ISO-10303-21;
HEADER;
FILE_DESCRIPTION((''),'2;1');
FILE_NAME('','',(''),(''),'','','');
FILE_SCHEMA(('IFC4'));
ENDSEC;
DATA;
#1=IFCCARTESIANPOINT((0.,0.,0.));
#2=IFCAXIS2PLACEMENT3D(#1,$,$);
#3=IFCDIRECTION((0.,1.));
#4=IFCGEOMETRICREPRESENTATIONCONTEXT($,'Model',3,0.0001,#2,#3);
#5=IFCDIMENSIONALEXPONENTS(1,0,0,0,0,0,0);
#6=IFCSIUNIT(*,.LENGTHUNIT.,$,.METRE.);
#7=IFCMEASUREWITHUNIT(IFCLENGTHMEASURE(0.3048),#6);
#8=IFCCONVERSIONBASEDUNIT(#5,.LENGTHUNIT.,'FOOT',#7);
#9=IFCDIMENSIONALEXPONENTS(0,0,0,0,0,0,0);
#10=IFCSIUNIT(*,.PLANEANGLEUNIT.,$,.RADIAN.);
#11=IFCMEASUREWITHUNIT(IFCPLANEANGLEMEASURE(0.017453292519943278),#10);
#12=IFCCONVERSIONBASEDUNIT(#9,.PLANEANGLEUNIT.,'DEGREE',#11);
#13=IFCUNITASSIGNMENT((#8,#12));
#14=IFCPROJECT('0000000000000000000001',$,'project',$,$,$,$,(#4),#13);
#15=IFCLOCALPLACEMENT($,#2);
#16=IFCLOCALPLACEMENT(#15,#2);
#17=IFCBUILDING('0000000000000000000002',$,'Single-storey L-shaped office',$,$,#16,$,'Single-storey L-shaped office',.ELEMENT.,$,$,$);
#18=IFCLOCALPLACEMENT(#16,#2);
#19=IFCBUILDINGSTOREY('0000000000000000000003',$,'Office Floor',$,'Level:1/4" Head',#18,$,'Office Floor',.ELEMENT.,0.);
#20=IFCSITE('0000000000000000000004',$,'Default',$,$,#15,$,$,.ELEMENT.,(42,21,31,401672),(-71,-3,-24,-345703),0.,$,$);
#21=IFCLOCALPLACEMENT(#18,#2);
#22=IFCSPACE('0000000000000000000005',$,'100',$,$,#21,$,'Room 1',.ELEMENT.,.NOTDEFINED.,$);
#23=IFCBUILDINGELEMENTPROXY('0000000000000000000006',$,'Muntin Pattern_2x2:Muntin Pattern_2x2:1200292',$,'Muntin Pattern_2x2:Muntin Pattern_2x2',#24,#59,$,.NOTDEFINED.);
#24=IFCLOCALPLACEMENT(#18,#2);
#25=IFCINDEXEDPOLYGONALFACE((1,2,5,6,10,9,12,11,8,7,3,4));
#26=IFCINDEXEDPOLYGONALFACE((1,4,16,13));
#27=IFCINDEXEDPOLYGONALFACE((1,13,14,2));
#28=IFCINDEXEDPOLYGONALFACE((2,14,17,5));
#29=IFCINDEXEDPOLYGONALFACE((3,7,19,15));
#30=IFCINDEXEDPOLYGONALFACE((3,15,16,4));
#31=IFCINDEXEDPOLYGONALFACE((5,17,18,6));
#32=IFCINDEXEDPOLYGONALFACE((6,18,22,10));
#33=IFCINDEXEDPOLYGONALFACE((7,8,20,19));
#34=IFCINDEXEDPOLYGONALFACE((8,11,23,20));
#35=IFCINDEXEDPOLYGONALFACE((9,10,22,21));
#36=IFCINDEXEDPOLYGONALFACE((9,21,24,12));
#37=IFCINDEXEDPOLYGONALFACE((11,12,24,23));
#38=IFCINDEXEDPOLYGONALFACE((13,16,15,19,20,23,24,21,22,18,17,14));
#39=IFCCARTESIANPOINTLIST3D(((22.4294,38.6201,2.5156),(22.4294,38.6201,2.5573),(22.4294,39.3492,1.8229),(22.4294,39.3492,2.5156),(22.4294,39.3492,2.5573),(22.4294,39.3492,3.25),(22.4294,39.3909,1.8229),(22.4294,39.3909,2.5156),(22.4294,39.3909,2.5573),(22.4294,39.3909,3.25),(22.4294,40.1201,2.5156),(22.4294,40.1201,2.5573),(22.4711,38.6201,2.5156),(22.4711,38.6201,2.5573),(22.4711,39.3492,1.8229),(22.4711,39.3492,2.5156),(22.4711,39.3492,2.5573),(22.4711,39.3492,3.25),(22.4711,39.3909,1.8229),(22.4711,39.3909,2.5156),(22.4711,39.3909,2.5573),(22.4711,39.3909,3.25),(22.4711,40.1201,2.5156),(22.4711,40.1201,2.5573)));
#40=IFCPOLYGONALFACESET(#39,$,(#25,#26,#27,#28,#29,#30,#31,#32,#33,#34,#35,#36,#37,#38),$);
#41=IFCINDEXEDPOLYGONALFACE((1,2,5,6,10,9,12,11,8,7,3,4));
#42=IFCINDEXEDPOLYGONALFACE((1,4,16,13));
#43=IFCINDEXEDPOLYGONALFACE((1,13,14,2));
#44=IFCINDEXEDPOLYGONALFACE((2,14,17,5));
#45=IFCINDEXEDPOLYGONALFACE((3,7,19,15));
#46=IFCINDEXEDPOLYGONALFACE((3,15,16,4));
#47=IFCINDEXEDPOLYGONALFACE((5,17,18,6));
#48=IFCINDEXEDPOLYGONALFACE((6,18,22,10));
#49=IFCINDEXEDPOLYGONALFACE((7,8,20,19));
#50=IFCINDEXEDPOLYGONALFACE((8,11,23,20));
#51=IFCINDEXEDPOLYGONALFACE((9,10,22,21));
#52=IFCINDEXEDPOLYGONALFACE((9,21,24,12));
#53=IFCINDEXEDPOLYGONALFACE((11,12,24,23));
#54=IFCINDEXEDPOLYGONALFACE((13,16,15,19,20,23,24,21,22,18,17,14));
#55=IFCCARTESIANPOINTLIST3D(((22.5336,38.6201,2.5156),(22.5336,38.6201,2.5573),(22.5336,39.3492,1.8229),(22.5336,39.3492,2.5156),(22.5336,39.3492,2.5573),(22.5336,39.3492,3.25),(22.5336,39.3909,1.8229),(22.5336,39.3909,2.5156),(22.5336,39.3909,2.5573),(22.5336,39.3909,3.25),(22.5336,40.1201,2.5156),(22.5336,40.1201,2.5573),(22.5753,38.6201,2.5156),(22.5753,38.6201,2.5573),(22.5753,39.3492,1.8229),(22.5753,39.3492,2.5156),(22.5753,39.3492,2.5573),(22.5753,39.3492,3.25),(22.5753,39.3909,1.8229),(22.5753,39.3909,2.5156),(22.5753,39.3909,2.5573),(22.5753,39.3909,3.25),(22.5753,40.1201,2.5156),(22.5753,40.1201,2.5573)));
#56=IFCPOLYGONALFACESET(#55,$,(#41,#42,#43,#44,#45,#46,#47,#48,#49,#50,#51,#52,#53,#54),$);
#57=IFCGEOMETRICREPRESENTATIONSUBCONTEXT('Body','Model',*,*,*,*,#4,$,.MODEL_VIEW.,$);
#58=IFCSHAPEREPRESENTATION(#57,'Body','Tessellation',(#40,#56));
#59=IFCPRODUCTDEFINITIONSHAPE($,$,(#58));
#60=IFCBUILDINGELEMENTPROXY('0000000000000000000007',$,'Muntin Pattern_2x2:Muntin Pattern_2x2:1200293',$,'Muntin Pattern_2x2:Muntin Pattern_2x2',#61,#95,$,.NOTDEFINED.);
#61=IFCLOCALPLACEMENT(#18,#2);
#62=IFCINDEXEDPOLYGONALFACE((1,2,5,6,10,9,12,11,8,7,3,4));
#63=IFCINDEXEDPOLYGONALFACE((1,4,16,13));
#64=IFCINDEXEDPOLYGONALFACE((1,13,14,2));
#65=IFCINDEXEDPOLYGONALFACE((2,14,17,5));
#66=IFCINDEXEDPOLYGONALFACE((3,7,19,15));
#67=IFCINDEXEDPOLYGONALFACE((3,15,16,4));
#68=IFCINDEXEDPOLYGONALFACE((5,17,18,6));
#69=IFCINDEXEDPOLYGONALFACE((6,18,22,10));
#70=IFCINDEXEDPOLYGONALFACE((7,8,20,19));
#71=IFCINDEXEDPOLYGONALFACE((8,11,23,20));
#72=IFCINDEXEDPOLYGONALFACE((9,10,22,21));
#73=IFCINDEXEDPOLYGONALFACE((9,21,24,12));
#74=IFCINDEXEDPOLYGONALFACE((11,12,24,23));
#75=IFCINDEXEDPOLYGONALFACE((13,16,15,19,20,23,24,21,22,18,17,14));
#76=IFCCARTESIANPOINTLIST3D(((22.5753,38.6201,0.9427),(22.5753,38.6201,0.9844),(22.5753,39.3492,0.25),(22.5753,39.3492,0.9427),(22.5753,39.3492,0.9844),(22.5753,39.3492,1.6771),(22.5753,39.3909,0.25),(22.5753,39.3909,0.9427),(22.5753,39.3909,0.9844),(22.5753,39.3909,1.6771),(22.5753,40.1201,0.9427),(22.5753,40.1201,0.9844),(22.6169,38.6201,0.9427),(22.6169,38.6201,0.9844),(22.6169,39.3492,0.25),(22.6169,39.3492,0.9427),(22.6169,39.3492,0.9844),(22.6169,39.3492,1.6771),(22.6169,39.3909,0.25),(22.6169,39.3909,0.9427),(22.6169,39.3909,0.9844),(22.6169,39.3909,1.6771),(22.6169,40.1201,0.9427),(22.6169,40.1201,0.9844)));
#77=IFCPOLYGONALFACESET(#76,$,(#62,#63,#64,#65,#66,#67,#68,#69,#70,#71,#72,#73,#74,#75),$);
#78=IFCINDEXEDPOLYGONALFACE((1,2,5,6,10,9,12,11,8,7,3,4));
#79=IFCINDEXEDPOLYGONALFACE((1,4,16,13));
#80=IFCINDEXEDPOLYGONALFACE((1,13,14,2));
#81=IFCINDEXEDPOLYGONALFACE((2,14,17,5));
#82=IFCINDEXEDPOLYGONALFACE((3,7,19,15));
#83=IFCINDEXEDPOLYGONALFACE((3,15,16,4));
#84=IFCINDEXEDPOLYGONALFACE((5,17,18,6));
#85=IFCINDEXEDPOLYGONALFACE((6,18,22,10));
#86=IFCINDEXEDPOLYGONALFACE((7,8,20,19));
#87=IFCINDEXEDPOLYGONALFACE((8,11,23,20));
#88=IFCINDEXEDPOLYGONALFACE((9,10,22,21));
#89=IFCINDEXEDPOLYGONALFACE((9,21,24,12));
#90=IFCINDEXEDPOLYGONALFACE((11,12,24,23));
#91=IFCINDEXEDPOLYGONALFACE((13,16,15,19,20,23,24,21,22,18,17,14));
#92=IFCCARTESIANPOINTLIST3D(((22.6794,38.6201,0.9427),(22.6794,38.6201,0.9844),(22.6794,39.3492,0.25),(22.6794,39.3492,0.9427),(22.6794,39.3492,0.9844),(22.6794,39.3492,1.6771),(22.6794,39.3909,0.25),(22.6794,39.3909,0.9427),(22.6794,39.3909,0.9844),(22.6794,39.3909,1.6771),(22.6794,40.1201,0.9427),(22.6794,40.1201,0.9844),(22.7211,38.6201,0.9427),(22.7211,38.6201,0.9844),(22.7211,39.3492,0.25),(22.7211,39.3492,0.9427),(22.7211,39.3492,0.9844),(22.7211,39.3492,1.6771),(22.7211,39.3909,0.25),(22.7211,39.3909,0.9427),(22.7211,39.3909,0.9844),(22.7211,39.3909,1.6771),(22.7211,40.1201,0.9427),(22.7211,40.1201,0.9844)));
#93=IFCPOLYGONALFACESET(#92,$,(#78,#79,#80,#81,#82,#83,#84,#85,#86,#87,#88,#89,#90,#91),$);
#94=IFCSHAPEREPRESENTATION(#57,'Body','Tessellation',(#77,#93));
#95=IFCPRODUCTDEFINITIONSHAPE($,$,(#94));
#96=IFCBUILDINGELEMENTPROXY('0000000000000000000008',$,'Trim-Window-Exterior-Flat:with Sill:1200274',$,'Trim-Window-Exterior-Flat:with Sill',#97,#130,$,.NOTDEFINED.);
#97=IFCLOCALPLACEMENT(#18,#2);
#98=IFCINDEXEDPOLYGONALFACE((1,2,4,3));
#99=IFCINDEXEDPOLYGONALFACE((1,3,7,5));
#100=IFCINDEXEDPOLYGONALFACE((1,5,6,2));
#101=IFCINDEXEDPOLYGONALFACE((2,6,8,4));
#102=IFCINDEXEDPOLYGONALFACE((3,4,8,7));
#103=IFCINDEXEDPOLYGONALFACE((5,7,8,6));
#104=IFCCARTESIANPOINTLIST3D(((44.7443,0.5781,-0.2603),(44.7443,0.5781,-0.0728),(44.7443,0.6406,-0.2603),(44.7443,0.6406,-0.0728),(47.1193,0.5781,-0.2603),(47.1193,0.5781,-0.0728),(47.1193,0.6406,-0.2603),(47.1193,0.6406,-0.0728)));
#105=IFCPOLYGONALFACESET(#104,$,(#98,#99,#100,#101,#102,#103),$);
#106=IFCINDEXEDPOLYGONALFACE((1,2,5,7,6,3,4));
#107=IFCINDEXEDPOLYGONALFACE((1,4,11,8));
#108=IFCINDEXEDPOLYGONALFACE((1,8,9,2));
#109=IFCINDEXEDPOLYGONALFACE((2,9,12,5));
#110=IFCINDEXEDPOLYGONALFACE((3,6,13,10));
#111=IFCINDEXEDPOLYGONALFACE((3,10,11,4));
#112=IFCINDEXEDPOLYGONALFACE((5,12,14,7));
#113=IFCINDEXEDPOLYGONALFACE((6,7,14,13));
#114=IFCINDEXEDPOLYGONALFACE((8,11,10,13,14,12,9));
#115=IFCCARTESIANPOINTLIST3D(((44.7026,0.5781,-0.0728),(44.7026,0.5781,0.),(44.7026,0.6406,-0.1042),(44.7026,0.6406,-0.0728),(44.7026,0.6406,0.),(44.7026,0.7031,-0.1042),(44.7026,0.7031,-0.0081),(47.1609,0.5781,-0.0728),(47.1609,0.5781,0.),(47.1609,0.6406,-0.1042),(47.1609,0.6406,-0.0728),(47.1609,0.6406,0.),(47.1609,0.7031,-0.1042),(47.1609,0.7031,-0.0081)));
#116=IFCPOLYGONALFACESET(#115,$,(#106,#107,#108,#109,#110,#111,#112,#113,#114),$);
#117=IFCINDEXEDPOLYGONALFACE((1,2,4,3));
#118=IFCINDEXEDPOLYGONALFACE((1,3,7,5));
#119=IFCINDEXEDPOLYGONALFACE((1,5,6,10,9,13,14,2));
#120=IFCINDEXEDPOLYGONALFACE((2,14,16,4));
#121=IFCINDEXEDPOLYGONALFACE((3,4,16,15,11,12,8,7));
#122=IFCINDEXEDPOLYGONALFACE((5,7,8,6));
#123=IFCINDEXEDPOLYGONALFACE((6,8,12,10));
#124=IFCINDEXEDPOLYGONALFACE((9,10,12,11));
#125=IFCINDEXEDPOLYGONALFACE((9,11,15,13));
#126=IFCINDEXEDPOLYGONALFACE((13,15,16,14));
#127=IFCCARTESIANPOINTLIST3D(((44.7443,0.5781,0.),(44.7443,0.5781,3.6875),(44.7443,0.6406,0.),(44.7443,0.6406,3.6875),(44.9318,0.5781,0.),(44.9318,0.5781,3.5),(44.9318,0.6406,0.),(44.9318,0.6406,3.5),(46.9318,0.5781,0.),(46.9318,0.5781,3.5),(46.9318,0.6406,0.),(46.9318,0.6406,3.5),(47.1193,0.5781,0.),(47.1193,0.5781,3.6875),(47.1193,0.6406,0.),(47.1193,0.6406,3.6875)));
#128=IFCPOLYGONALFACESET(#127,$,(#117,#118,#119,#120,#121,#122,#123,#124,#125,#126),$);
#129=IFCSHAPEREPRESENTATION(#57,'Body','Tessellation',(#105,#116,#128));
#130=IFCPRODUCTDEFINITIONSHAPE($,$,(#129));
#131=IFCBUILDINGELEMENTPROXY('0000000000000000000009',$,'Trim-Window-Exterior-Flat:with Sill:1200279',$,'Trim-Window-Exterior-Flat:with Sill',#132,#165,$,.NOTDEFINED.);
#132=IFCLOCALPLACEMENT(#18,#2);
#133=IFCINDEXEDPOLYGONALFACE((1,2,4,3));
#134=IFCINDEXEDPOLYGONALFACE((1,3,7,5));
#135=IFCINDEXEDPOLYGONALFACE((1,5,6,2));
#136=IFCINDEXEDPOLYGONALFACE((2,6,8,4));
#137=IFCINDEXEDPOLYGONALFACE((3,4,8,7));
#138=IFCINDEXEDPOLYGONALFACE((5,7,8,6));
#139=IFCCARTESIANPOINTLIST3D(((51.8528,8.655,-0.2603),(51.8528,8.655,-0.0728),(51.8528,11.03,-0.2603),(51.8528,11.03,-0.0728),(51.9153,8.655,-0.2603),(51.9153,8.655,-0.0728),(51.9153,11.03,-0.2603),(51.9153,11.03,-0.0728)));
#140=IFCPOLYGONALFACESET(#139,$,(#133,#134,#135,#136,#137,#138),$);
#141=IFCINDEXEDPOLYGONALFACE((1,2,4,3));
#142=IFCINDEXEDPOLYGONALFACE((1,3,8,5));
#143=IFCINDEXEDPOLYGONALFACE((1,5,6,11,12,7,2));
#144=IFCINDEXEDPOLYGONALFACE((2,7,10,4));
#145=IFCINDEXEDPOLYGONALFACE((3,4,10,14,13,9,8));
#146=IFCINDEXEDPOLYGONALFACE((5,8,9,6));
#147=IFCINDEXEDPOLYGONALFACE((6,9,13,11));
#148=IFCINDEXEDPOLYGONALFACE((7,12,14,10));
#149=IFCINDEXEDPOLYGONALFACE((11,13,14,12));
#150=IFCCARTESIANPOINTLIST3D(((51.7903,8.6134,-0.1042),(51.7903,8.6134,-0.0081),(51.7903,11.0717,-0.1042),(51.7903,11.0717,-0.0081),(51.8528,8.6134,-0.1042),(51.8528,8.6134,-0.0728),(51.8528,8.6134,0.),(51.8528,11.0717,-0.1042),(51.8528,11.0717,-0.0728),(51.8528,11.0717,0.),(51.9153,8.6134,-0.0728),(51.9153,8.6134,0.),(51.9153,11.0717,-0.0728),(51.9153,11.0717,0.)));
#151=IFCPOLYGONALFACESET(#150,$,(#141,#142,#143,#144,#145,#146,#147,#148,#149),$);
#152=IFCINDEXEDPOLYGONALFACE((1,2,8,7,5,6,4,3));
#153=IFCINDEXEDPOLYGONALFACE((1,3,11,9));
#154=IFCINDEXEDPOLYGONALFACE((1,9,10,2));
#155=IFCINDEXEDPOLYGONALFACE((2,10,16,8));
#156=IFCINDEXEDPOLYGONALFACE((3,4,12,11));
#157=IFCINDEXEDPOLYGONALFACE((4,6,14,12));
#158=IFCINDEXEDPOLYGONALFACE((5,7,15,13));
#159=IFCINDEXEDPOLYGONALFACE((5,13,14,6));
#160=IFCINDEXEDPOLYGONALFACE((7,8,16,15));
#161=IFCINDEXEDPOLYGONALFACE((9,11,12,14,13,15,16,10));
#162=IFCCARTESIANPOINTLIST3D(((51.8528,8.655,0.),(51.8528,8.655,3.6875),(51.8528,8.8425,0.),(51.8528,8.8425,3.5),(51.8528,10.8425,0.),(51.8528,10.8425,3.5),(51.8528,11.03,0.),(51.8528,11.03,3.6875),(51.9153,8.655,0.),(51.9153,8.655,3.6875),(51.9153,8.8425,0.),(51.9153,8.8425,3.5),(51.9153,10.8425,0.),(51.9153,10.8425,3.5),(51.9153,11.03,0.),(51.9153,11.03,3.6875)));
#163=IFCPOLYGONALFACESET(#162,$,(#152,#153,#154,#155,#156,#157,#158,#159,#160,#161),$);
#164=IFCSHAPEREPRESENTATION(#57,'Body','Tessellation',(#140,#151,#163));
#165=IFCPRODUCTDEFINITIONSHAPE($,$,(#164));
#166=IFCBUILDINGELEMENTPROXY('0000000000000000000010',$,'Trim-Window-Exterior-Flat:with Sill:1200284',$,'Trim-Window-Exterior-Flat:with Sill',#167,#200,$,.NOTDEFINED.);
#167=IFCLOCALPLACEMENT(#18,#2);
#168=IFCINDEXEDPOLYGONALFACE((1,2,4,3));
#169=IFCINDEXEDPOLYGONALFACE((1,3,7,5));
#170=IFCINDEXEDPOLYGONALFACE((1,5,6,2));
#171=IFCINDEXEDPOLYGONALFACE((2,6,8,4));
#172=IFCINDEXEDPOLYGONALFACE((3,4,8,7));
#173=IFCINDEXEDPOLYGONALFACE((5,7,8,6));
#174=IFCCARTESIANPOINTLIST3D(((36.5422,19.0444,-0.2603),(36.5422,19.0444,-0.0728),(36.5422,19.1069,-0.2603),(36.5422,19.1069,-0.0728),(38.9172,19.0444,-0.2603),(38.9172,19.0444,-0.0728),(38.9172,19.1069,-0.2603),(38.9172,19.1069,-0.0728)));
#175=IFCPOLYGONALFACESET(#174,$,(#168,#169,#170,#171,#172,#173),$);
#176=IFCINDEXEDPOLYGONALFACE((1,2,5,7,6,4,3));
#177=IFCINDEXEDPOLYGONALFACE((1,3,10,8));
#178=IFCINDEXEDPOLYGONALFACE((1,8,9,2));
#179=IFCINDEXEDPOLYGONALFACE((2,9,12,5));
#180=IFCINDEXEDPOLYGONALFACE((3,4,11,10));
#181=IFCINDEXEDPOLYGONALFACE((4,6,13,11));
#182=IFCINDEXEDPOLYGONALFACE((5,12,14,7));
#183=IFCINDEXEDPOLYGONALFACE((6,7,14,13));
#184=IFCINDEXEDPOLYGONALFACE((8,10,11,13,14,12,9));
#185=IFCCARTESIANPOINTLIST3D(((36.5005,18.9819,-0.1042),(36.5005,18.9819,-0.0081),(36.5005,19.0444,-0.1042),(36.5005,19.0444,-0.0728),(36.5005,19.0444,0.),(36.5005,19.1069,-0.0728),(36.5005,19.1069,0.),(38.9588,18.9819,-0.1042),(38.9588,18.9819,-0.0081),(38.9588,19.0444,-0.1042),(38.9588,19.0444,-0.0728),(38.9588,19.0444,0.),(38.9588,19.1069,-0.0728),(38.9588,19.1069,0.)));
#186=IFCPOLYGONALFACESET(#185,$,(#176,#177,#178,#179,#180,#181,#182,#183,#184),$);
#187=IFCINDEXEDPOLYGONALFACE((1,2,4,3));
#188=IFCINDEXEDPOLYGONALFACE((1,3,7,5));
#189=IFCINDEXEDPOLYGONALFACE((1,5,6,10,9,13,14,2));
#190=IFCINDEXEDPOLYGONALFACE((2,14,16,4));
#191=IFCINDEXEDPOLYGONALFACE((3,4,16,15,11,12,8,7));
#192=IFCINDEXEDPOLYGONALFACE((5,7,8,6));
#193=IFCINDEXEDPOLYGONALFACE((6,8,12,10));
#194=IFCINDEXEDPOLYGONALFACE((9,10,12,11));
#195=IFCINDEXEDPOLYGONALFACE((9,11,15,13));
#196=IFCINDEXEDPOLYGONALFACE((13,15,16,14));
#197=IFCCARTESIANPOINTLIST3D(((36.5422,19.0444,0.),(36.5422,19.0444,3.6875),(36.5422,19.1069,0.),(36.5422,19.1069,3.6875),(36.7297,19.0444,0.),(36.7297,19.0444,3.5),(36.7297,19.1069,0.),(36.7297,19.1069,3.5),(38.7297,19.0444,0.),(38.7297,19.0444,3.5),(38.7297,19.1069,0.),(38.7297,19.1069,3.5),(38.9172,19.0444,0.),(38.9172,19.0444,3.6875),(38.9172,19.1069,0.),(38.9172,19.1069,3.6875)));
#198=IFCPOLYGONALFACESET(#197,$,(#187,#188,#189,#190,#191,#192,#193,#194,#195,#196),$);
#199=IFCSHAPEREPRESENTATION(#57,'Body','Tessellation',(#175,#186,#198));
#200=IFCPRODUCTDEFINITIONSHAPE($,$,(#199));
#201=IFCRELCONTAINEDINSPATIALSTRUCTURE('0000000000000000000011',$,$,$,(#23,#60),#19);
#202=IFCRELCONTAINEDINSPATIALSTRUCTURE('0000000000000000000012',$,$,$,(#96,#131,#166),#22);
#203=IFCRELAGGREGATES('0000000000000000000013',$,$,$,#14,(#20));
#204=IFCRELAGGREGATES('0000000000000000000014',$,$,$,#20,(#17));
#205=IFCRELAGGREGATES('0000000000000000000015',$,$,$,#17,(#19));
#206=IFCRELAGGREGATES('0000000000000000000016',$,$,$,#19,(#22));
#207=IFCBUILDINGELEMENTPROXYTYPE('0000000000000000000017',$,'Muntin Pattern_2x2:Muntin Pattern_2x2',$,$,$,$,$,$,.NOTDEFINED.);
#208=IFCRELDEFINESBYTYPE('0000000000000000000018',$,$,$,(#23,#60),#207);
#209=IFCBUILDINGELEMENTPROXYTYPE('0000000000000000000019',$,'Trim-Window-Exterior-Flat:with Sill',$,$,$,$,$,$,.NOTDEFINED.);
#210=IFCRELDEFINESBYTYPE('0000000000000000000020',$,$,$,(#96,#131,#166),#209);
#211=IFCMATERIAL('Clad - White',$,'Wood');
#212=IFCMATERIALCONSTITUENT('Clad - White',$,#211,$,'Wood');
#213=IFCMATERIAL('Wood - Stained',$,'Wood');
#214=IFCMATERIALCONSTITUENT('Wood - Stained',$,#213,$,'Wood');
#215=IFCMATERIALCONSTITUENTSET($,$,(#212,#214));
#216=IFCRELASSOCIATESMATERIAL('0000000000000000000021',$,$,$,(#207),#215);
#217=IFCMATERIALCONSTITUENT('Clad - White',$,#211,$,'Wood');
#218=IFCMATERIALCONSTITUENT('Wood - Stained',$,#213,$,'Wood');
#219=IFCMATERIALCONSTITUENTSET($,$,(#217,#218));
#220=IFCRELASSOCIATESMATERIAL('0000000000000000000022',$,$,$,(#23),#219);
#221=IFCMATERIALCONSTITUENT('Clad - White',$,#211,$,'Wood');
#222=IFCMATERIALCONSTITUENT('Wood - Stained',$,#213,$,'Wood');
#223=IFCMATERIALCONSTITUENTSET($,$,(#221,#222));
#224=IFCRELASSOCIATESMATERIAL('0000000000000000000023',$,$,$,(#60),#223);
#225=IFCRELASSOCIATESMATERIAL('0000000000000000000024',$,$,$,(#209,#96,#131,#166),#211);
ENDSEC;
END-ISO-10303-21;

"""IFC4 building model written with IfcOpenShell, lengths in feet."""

from ifc_helpers import new_model, entity, si_unit, converted_unit, direction, frame, origin, place, context, subcontext, project, spatial, indexed_curve, outline, extrude, source, transform, mapped, material, constituent, constituent_set, type_object, type_shapes, element, save


model = new_model("IFC4")

# Units and contexts
model_context = context("Model", 3, precision=0.0001, world=origin(), true_north=direction((0.0, 1.0)))
body_context = subcontext(model_context, "Body", "Model", "MODEL_VIEW")
ifc_project = project(units=[converted_unit("LENGTHUNIT", "FOOT", entity("IfcLengthMeasure", 0.3048), si_unit("LENGTHUNIT", "METRE"), dimensions=[1, 0, 0, 0, 0, 0, 0]), converted_unit("PLANEANGLEUNIT", "DEGREE", entity("IfcPlaneAngleMeasure", 0.017453292519943278), si_unit("PLANEANGLEUNIT", "RADIAN"), dimensions=[0, 0, 0, 0, 0, 0, 0])], contexts=[model_context])

# Site, building, storey
site_placement = place(None, origin())
site = spatial("IfcSite", under=ifc_project, at=site_placement, Name="Default", CompositionType="ELEMENT", RefLatitude=(42, 21, 31, 401672), RefLongitude=(-71, -3, -24, -345703), RefElevation=0.0)
building_placement = place(site_placement, origin())
building = spatial("IfcBuilding", under=site, at=building_placement, Name="Single-storey L-shaped office", LongName="Single-storey L-shaped office", CompositionType="ELEMENT")
storey_placement = place(building_placement, origin())
storey = spatial("IfcBuildingStorey", under=building, at=storey_placement, Name="Office Floor", ObjectType="Level:1/4\" Head", LongName="Office Floor", CompositionType="ELEMENT", Elevation=0.0)

# Shared definitions
ifc_material_1 = material(Name="Wood - Stained", Category="Wood")

# Building element proxies
ifc_material_2 = material(Name="Clad - White", Category="Wood")
ifc_constituent_1 = constituent(ifc_material_2, Name="Clad - White", Category="Wood")
ifc_constituent_2 = constituent(ifc_material_1, Name="Wood - Stained", Category="Wood")
ifc_constituent_set_1 = constituent_set(constituents=[ifc_constituent_1, ifc_constituent_2])
building_element_proxy_type_1 = type_object("IfcBuildingElementProxyType", Name="Muntin Pattern_2x2:Muntin Pattern_2x2", PredefinedType="NOTDEFINED", material=ifc_constituent_set_1)
shared_shape_1 = source(origin(), body_context, "Body", "SweptSolid", [
    extrude(outline(indexed_curve([(0.0208, -0.0208), (0.7135, -0.0208), (0.7135, 0.0208), (0.0208, 0.0208), (0.0208, 0.75), (-0.0208, 0.75), (-0.0208, 0.0208), (-0.7135, 0.0208), (-0.7135, -0.0208), (-0.0208, -0.0208), (-0.0208, -0.75), (0.0208, -0.75), (0.0208, -0.0208)], self_intersect=False)), frame((0.0, 0.0312, 0.7135), z_axis=(0.0, 1.0, 0.0), x_axis=(0.0, 0.0, 1.0)), (0.0, 0.0, 1.0), 0.0417),
    extrude(outline(indexed_curve([(0.0208, -0.0208), (0.7135, -0.0208), (0.7135, 0.0208), (0.0208, 0.0208), (0.0208, 0.75), (-0.0208, 0.75), (-0.0208, 0.0208), (-0.7135, 0.0208), (-0.7135, -0.0208), (-0.0208, -0.0208), (-0.0208, -0.75), (0.0208, -0.75), (0.0208, -0.0208)], self_intersect=False)), frame((0.0, -0.0729, 0.7135), z_axis=(0.0, 1.0, 0.0), x_axis=(0.0, 0.0, 1.0)), (0.0, 0.0, 1.0), 0.0417),
])
type_shapes(building_element_proxy_type_1, [shared_shape_1])
ifc_constituent_3 = constituent(ifc_material_2, Name="Clad - White", Category="Wood")
ifc_constituent_4 = constituent(ifc_material_1, Name="Wood - Stained", Category="Wood")
ifc_constituent_set_2 = constituent_set(constituents=[ifc_constituent_3, ifc_constituent_4])
proxy_1_placement = place(storey_placement, frame((22.5023, 39.3701, 1.8229), z_axis=(0.0, 0.0, 1.0), x_axis=(0.0, 1.0, 0.0)))
element("IfcBuildingElementProxy", 1, at=proxy_1_placement, inside=storey, type_object=building_element_proxy_type_1, material=ifc_constituent_set_2, Name="Muntin Pattern_2x2:Muntin Pattern_2x2:1200292", ObjectType="Muntin Pattern_2x2:Muntin Pattern_2x2", PredefinedType="NOTDEFINED", context=body_context, shape_type="MappedRepresentation", body=[
    mapped(shared_shape_1, transform((0.0, 0.0, 0.0), scale=1.0)),
])
ifc_constituent_5 = constituent(ifc_material_2, Name="Clad - White", Category="Wood")
ifc_constituent_6 = constituent(ifc_material_1, Name="Wood - Stained", Category="Wood")
ifc_constituent_set_3 = constituent_set(constituents=[ifc_constituent_5, ifc_constituent_6])
proxy_2_placement = place(storey_placement, frame((22.6482, 39.3701, 0.25), z_axis=(0.0, 0.0, 1.0), x_axis=(0.0, 1.0, 0.0)))
element("IfcBuildingElementProxy", 2, at=proxy_2_placement, inside=storey, type_object=building_element_proxy_type_1, material=ifc_constituent_set_3, Name="Muntin Pattern_2x2:Muntin Pattern_2x2:1200293", ObjectType="Muntin Pattern_2x2:Muntin Pattern_2x2", PredefinedType="NOTDEFINED", context=body_context, shape_type="MappedRepresentation", body=[
    mapped(shared_shape_1, transform((0.0, 0.0, 0.0), scale=1.0)),
])

# Shared definitions
space_1_placement = place(storey_placement, origin())
space_1 = spatial("IfcSpace", under=storey, at=space_1_placement, Name="100", LongName="Room 1", CompositionType="ELEMENT", PredefinedType="NOTDEFINED")

# Building element proxies
building_element_proxy_type_2 = type_object("IfcBuildingElementProxyType", Name="Trim-Window-Exterior-Flat:with Sill", PredefinedType="NOTDEFINED", material=ifc_material_2)
shared_shape_2 = source(origin(), body_context, "Body", "SweptSolid", [
    extrude(outline(indexed_curve([(-1.1875, -0.0938), (1.1875, -0.0938), (1.1875, 0.0938), (-1.1875, 0.0938), (-1.1875, -0.0938)], self_intersect=False)), frame((0.0, -3.6665, 0.0), z_axis=(0.0, 0.0, 1.0), x_axis=(-1.0, 0.0, 0.0)), (0.0, 0.0, 1.0), 0.0625),
    extrude(outline(indexed_curve([(-0.0625, -0.0525), (0.0, -0.0525), (0.0, -0.0211), (0.0625, -0.0211), (0.0625, 0.0517), (0.0, 0.0517), (-0.0625, 0.0436), (-0.0625, -0.0525)], self_intersect=False)), frame((-1.2292, -3.5517, 0.0625), z_axis=(1.0, 0.0, 0.0), x_axis=(0.0, 0.0, -1.0)), (0.0, 0.0, 1.0), 2.4583),
    extrude(outline(indexed_curve([(-1.8906, -1.1875), (1.7969, -1.1875), (1.7969, -1.0), (-1.7031, -1.0), (-1.7031, 1.0), (1.7969, 1.0), (1.7969, 1.1875), (-1.8906, 1.1875), (-1.8906, -1.1875)], self_intersect=False)), frame((0.0, -1.7031, 0.0), z_axis=(0.0, 0.0, 1.0), x_axis=(0.0, -1.0, 0.0)), (0.0, 0.0, 1.0), 0.0625),
])
type_shapes(building_element_proxy_type_2, [shared_shape_2])
for number, where, z_axis, x_axis, name in (
    (3, (45.9318, 0.5781, 3.5), (0.0, 1.0, 0.0), (-1.0, 0.0, 0.0), "Trim-Window-Exterior-Flat:with Sill:1200274"),
    (4, (51.9153, 9.8425, 3.5), (-1.0, 0.0, 0.0), (0.0, -1.0, 0.0), "Trim-Window-Exterior-Flat:with Sill:1200279"),
    (5, (37.7297, 19.1069, 3.5), (0.0, -1.0, 0.0), (1.0, 0.0, 0.0), "Trim-Window-Exterior-Flat:with Sill:1200284"),
):
    element("IfcBuildingElementProxy", number, at=place(space_1_placement, frame(where, z_axis=z_axis, x_axis=x_axis)), inside=space_1, type_object=building_element_proxy_type_2, material=ifc_material_2, Name=name, ObjectType="Trim-Window-Exterior-Flat:with Sill", PredefinedType="NOTDEFINED", context=body_context, shape_type="MappedRepresentation", body=[
        mapped(shared_shape_2, transform((0.0, 0.0, 0.0), scale=1.0)),
    ])

save(model, "model.ifc")
